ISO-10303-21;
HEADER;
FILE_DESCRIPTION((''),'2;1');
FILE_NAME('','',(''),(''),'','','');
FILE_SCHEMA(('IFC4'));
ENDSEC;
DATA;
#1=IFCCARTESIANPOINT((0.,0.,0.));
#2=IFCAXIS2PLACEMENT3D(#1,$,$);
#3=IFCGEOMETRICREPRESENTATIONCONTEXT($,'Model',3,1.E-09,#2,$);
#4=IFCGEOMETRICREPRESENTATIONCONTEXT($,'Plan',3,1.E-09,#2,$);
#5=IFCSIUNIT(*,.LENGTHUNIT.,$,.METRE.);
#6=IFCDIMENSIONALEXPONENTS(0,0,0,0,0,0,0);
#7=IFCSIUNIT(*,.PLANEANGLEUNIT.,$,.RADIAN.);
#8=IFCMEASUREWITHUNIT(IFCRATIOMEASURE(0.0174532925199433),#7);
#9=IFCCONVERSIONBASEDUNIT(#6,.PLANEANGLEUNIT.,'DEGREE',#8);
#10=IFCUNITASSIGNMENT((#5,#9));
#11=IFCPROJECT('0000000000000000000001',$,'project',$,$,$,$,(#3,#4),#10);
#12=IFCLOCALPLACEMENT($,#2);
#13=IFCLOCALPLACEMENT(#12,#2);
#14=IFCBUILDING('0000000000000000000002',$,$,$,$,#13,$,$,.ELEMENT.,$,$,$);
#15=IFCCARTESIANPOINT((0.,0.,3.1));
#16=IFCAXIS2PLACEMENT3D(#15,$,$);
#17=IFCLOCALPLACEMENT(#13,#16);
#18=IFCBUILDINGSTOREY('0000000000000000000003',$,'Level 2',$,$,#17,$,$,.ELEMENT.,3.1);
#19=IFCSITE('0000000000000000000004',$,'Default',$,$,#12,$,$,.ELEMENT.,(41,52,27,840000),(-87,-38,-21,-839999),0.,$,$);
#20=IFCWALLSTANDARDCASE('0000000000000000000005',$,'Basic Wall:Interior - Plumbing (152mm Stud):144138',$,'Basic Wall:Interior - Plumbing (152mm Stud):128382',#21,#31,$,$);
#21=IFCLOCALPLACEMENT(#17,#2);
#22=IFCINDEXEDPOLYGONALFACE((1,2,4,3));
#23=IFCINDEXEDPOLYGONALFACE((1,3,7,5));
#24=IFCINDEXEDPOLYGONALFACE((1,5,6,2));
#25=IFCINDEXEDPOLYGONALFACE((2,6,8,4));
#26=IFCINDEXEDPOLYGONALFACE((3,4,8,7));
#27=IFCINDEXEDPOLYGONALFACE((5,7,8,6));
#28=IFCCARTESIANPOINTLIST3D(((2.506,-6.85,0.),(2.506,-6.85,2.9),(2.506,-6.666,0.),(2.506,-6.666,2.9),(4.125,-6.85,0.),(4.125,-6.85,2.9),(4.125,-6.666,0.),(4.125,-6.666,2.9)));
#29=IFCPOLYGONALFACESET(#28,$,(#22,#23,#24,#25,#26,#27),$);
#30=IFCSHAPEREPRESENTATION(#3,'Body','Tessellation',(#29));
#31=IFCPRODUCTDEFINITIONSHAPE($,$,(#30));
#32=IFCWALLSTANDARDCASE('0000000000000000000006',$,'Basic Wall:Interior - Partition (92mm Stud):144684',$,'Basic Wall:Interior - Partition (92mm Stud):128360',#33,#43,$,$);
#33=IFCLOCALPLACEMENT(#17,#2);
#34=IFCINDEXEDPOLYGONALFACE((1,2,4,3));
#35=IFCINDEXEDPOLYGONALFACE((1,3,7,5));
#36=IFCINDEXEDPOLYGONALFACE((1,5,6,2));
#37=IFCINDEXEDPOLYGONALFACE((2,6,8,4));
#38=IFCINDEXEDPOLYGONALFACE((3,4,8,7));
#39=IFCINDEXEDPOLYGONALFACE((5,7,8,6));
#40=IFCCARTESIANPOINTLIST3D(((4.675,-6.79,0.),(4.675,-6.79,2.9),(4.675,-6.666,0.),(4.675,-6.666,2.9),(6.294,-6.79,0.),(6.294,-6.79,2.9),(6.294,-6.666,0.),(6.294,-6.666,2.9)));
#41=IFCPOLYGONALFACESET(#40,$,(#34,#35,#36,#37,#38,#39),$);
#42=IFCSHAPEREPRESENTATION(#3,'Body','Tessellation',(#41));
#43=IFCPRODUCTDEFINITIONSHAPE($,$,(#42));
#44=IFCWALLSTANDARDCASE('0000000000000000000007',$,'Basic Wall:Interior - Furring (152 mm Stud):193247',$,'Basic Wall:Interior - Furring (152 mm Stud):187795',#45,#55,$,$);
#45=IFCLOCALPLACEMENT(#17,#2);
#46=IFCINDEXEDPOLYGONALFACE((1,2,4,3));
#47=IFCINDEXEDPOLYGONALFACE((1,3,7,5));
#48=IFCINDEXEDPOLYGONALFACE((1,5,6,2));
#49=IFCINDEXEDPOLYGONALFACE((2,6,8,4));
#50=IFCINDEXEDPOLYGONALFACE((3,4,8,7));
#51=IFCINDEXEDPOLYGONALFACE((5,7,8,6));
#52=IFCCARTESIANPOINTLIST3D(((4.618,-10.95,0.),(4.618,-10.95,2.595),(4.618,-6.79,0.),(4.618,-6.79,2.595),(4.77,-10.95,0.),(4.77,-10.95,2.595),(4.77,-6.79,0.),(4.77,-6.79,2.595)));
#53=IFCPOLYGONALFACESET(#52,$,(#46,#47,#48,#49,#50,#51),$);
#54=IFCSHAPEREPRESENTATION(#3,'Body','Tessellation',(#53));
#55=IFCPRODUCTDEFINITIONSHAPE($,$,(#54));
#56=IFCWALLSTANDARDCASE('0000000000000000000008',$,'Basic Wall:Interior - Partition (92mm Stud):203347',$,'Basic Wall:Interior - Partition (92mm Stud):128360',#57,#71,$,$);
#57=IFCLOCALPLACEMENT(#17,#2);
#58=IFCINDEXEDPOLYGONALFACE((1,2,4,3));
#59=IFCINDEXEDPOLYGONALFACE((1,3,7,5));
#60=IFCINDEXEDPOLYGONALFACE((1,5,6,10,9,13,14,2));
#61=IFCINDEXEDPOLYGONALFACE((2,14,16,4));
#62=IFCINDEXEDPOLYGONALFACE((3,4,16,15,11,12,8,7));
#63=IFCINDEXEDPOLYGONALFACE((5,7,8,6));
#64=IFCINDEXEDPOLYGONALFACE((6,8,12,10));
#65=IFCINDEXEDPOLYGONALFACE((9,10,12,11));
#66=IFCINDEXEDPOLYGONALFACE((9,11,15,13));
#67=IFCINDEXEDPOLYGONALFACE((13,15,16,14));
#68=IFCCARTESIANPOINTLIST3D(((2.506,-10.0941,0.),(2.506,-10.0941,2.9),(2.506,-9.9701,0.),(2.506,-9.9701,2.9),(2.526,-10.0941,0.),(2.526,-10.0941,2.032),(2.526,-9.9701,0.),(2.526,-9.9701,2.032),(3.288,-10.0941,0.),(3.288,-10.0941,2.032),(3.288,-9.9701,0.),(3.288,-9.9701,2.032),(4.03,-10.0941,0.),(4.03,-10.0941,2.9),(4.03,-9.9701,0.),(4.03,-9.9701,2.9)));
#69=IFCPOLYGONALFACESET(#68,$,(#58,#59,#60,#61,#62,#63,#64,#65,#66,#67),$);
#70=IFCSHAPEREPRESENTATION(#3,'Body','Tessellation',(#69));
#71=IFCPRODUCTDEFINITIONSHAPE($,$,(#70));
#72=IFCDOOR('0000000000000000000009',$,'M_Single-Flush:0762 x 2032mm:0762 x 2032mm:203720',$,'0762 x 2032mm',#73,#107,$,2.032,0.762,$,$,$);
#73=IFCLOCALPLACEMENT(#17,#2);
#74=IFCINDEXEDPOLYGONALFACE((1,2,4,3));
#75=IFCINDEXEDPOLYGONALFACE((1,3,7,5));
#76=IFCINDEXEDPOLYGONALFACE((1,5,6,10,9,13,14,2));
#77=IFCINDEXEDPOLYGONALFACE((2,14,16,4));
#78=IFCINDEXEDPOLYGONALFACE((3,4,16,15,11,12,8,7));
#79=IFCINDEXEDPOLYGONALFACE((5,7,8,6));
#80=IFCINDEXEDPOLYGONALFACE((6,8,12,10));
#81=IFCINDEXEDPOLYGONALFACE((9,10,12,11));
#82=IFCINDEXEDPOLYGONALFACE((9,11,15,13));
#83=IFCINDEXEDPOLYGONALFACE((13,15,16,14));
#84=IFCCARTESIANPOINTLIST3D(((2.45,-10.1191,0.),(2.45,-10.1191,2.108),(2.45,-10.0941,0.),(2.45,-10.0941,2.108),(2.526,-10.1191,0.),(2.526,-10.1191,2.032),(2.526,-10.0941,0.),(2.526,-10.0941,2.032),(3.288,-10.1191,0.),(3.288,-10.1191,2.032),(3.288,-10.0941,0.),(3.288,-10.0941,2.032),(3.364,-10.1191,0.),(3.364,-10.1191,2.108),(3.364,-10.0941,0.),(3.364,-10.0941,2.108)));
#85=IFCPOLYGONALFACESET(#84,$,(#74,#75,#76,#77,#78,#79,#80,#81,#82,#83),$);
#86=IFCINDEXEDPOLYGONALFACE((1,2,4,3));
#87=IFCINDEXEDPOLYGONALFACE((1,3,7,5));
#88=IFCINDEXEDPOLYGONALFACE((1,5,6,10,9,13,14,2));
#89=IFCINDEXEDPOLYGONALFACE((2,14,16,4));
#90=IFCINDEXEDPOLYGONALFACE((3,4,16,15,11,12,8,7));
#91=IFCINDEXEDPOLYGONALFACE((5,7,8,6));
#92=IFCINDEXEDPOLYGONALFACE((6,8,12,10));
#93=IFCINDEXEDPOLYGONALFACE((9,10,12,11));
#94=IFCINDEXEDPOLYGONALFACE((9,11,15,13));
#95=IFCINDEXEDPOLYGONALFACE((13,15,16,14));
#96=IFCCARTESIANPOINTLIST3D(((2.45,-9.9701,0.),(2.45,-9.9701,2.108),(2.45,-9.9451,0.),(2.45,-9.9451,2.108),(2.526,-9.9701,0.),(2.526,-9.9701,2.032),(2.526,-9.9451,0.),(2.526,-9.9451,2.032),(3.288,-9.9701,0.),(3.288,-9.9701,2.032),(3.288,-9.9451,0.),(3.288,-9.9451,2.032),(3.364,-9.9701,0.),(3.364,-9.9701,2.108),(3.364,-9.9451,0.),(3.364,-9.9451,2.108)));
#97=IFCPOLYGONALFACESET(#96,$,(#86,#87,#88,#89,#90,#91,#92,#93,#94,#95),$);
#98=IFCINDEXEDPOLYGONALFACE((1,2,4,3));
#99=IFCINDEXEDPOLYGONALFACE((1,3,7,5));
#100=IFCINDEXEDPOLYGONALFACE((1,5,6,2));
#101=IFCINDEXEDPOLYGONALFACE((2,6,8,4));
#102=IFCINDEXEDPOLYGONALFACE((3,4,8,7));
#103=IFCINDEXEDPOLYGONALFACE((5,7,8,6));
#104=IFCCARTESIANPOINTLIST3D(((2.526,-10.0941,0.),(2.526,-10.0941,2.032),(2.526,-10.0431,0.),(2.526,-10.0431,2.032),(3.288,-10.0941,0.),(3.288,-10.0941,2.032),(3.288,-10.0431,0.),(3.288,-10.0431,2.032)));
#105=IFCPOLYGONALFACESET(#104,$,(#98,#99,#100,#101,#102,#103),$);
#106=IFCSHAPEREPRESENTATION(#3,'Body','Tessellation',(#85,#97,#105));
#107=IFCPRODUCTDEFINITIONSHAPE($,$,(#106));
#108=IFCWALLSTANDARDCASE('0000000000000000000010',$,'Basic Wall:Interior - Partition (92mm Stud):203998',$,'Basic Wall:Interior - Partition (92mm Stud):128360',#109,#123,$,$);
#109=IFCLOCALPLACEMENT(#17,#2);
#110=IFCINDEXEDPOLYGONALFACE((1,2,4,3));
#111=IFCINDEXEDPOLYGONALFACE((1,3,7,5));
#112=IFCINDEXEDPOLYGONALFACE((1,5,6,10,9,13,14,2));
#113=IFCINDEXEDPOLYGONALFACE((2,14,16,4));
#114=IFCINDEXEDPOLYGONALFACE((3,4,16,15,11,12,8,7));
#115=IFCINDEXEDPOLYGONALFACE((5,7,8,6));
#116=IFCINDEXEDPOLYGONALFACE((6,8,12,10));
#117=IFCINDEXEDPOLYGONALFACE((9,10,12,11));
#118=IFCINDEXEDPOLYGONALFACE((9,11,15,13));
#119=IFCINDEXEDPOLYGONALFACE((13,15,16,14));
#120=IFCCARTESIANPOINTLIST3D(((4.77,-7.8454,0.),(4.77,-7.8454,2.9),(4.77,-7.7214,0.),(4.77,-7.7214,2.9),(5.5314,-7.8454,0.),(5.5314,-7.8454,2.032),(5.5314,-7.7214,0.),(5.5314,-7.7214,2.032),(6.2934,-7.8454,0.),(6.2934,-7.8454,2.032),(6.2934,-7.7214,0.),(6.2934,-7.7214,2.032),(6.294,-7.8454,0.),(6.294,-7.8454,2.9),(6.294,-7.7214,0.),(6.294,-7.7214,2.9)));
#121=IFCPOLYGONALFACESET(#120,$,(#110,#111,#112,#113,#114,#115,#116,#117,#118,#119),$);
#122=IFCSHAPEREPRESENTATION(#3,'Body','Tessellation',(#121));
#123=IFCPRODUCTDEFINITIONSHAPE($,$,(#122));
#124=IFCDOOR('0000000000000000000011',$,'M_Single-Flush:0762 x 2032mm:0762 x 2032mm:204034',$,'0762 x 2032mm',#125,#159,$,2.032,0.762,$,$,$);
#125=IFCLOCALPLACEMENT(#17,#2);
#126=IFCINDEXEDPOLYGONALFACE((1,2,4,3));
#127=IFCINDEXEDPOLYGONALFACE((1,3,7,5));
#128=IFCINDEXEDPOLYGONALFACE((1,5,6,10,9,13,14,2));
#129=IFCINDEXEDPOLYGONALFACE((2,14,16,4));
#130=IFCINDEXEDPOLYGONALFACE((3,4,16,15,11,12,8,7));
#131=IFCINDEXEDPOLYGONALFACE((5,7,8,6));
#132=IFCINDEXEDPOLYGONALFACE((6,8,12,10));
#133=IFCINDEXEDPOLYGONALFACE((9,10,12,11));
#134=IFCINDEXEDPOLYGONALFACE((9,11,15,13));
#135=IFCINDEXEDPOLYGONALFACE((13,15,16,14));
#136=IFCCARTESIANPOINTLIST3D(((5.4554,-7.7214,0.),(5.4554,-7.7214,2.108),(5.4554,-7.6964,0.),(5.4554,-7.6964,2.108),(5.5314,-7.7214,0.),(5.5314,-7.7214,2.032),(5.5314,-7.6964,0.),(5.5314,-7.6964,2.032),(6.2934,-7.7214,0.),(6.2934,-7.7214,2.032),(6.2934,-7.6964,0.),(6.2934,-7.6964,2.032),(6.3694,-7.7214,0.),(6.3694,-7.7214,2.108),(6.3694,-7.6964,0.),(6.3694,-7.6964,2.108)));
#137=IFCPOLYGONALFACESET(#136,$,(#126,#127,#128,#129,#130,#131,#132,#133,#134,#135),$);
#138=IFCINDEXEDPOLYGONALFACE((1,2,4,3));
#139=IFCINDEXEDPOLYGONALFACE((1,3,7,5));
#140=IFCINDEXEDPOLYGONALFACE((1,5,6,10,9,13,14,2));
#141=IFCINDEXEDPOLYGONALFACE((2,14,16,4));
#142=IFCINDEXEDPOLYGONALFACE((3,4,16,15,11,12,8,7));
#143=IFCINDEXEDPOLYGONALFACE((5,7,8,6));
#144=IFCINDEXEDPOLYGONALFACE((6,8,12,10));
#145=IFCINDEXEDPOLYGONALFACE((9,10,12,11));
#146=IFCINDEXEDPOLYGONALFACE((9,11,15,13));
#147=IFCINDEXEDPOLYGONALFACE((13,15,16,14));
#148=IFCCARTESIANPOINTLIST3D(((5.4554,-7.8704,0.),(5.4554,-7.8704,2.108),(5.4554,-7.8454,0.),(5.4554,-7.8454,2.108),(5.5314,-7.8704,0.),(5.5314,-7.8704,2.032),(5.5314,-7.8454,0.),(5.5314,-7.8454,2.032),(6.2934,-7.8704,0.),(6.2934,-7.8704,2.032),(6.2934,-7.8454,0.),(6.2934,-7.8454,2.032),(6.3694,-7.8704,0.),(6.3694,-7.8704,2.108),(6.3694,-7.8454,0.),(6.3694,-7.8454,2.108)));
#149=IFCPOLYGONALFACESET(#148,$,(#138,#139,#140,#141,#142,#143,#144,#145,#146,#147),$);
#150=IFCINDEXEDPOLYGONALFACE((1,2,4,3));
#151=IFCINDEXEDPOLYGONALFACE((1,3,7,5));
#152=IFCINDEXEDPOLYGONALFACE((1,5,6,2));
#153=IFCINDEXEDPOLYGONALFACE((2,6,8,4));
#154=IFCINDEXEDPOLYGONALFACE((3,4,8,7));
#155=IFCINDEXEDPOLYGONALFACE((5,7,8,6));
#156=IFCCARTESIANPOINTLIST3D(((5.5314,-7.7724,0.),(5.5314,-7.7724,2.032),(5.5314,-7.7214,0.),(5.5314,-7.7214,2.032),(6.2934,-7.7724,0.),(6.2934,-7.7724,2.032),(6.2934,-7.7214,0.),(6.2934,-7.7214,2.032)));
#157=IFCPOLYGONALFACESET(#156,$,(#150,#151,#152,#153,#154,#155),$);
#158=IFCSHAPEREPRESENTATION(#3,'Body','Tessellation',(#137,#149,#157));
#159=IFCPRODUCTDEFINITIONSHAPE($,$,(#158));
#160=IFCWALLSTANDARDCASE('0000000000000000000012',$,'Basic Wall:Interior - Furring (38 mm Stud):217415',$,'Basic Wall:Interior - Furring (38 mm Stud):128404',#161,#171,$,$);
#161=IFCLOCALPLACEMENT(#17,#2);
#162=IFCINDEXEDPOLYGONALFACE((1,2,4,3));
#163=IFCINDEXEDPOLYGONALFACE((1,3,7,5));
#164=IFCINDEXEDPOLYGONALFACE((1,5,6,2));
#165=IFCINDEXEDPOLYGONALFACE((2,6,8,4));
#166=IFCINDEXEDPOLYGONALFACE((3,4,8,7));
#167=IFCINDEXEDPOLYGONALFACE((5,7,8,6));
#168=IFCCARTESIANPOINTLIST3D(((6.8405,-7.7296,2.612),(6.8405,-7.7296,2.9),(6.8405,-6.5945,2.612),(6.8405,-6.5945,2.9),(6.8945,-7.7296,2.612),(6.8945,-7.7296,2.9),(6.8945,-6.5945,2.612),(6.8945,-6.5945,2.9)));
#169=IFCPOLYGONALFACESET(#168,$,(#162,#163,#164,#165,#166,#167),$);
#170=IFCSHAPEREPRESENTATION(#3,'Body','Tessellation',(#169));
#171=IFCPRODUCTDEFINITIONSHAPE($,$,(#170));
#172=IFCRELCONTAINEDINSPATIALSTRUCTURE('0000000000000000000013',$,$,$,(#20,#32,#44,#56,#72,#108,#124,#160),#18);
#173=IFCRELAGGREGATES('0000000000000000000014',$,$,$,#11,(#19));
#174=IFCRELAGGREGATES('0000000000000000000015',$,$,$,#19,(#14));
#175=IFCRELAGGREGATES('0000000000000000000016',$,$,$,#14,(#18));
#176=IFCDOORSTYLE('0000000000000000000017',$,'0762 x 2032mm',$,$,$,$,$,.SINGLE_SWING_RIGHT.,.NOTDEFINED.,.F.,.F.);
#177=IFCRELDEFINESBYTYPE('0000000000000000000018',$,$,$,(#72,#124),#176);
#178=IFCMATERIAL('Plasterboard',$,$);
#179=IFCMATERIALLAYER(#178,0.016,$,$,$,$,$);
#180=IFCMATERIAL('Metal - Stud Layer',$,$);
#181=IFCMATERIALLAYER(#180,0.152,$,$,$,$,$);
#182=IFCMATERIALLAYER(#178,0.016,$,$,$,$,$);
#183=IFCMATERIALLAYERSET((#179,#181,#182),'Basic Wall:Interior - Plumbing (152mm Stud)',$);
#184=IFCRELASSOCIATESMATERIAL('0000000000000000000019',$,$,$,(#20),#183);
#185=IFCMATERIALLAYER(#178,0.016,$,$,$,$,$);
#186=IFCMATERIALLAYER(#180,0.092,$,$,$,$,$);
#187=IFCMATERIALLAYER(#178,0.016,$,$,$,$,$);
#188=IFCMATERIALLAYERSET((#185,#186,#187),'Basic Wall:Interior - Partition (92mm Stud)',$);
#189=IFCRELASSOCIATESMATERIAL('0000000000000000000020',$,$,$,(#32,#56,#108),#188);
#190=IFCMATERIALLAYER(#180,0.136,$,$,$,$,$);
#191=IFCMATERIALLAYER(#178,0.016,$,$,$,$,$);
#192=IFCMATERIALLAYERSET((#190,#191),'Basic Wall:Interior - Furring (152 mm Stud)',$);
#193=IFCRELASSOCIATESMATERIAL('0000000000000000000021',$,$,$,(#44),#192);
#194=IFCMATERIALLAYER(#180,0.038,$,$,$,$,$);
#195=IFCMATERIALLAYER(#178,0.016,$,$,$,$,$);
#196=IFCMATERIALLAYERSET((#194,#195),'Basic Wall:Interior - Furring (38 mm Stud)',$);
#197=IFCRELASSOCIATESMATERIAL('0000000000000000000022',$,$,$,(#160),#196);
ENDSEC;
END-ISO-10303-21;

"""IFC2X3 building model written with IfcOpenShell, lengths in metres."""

from ifc_helpers import new_model, entity, si_unit, converted_unit, frame, frame_2d, origin, origin_2d_with_axis, place, context, project, spatial, polyline, rectangle, outline, extrude, source, transform, mapped, material, layer, layer_set, layer_usage, type_object, type_shapes, element, fill, save


model = new_model("IFC2X3")

# Units and contexts
model_context = context("Model", 3, precision=1e-09, world=origin())
plan_context = context("Plan", 3, precision=1e-09, world=origin())
ifc_project = project(units=[si_unit("LENGTHUNIT", "METRE"), converted_unit("PLANEANGLEUNIT", "DEGREE", entity("IfcRatioMeasure", 0.0174532925199433), si_unit("PLANEANGLEUNIT", "RADIAN"), dimensions=[0, 0, 0, 0, 0, 0, 0])], contexts=[model_context, plan_context])

# Site, building, storey
site_placement = place(None, origin())
site = spatial("IfcSite", under=ifc_project, at=site_placement, Name="Default", CompositionType="ELEMENT", RefLatitude=(41, 52, 27, 840000), RefLongitude=(-87, -38, -21, -839999), RefElevation=0.0)
building_placement = place(site_placement, origin())
building = spatial("IfcBuilding", under=site, at=building_placement, CompositionType="ELEMENT")
storey_placement = place(building_placement, frame((0.0, 0.0, 3.1)))
storey = spatial("IfcBuildingStorey", under=building, at=storey_placement, Name="Level 2", CompositionType="ELEMENT", Elevation=3.1)

# Walls
ifc_material_1 = material(Name="Plasterboard")
ifc_layer_1 = layer(ifc_material_1, 0.016)
ifc_material_2 = material(Name="Metal - Stud Layer")
ifc_layer_2 = layer(ifc_material_2, 0.152)
ifc_layer_3 = layer(ifc_material_1, 0.016)
ifc_layer_set_1 = layer_set([ifc_layer_1, ifc_layer_2, ifc_layer_3], Name="Basic Wall:Interior - Plumbing (152mm Stud)")
ifc_layer_usage_1 = layer_usage(ifc_layer_set_1, "AXIS2", "NEGATIVE", 0.092)
wall_1_placement = place(storey_placement, frame((2.506, -6.758, 0.0)))
element("IfcWallStandardCase", 1, at=wall_1_placement, inside=storey, material=ifc_layer_usage_1, Name="Basic Wall:Interior - Plumbing (152mm Stud):144138", ObjectType="Basic Wall:Interior - Plumbing (152mm Stud):128382", context=model_context, shape_type="SweptSolid", body=[
    extrude(rectangle(XDim=1.619, YDim=0.184, at=frame_2d((0.8095, 0.0), x_axis=(-1.0, 0.0))), origin(), (0.0, 0.0, 1.0), 2.9),
])
ifc_layer_4 = layer(ifc_material_1, 0.016)
ifc_layer_5 = layer(ifc_material_2, 0.092)
ifc_layer_6 = layer(ifc_material_1, 0.016)
ifc_layer_set_2 = layer_set([ifc_layer_4, ifc_layer_5, ifc_layer_6], Name="Basic Wall:Interior - Partition (92mm Stud)")
ifc_layer_usage_2 = layer_usage(ifc_layer_set_2, "AXIS2", "NEGATIVE", 0.062)
wall_2_placement = place(storey_placement, frame((4.675, -6.728, 0.0)))
element("IfcWallStandardCase", 2, at=wall_2_placement, inside=storey, material=ifc_layer_usage_2, Name="Basic Wall:Interior - Partition (92mm Stud):144684", ObjectType="Basic Wall:Interior - Partition (92mm Stud):128360", context=model_context, shape_type="SweptSolid", body=[
    extrude(rectangle(XDim=1.619, YDim=0.124, at=frame_2d((0.8095, 0.0), x_axis=(-1.0, 0.0))), origin(), (0.0, 0.0, 1.0), 2.9),
])
ifc_layer_7 = layer(ifc_material_2, 0.136)
ifc_layer_8 = layer(ifc_material_1, 0.016)
ifc_layer_set_3 = layer_set([ifc_layer_7, ifc_layer_8], Name="Basic Wall:Interior - Furring (152 mm Stud)")
ifc_layer_usage_3 = layer_usage(ifc_layer_set_3, "AXIS2", "POSITIVE", -0.076)
wall_3_placement = place(storey_placement, frame((4.694, -6.79, 0.0), z_axis=(0.0, 0.0, 1.0), x_axis=(0.0, -1.0, 0.0)))
element("IfcWallStandardCase", 3, at=wall_3_placement, inside=storey, material=ifc_layer_usage_3, Name="Basic Wall:Interior - Furring (152 mm Stud):193247", ObjectType="Basic Wall:Interior - Furring (152 mm Stud):187795", context=model_context, shape_type="SweptSolid", body=[
    extrude(rectangle(XDim=4.16, YDim=0.152, at=frame_2d((2.08, 0.0), x_axis=(-1.0, 0.0))), origin(), (0.0, 0.0, 1.0), 2.595),
])

# Walls, openings, doors
ifc_layer_usage_4 = layer_usage(ifc_layer_set_2, "AXIS2", "NEGATIVE", 0.062)
wall_4_placement = place(storey_placement, frame((4.03, -10.0321, 0.0), z_axis=(0.0, 0.0, 1.0), x_axis=(-1.0, 0.0, 0.0)))
wall_4 = element("IfcWallStandardCase", 4, at=wall_4_placement, inside=storey, material=ifc_layer_usage_4, Name="Basic Wall:Interior - Partition (92mm Stud):203347", ObjectType="Basic Wall:Interior - Partition (92mm Stud):128360", context=model_context, shape_type="SweptSolid", body=[
    extrude(rectangle(XDim=1.524, YDim=0.124, at=frame_2d((0.762, 0.0), x_axis=(-1.0, 0.0))), origin(), (0.0, 0.0, 1.0), 2.9),
])
opening_1_placement = place(wall_4_placement, frame((0.742, -0.062, 0.0)))
opening_1 = element("IfcOpeningElement", 5, at=opening_1_placement, cuts=wall_4, ObjectType="Opening", context=model_context, shape_type="SweptSolid", body=[
    extrude(rectangle(XDim=0.762, YDim=2.032, at=frame_2d((1.016, 0.381), x_axis=(0.0, 1.0))), frame((0.0, 0.0, 0.0), z_axis=(0.0, 1.0, 0.0), x_axis=(0.0, 0.0, 1.0)), (0.0, 0.0, 1.0), 0.124),
])
door_style = type_object("IfcDoorStyle", Name="0762 x 2032mm", ConstructionType="NOTDEFINED", OperationType="SINGLE_SWING_RIGHT", ParameterTakesPrecedence=False, Sizeable=False)
shared_shape = source(origin(), model_context, "Body", "SweptSolid", [
    extrude(outline(polyline([(-0.457, -1.073), (0.457, -1.073), (0.457, 1.035), (0.381, 1.035), (0.381, -0.997), (-0.381, -0.997), (-0.381, 1.035), (-0.457, 1.035), (-0.457, -1.073)])), frame((0.381, 0.124, 1.035), z_axis=(0.0, 1.0, 0.0), x_axis=(1.0, 0.0, 0.0)), (0.0, 0.0, 1.0), 0.025),
    extrude(outline(polyline([(-1.073, -0.457), (1.035, -0.457), (1.035, -0.381), (-0.997, -0.381), (-0.997, 0.381), (1.035, 0.381), (1.035, 0.457), (-1.073, 0.457), (-1.073, -0.457)])), frame((0.381, -0.025, 1.035), z_axis=(0.0, 1.0, 0.0), x_axis=(0.0, 0.0, -1.0)), (0.0, 0.0, 1.0), 0.025),
    extrude(rectangle(XDim=0.051, YDim=0.762, at=origin_2d_with_axis()), frame((0.381, 0.0985, 0.0), z_axis=(0.0, 0.0, 1.0), x_axis=(0.0, 1.0, 0.0)), (0.0, 0.0, 1.0), 2.032),
])
type_shapes(door_style, [shared_shape])
door_1_placement = place(opening_1_placement, origin())
door_1 = element("IfcDoor", 6, at=door_1_placement, inside=storey, type_object=door_style, Name="M_Single-Flush:0762 x 2032mm:0762 x 2032mm:203720", ObjectType="0762 x 2032mm", OverallHeight=2.032, OverallWidth=0.762, context=model_context, shape_type="MappedRepresentation", body=[
    mapped(shared_shape, transform((0.0, 0.0, 0.0), scale=1.0)),
])
fill(opening_1, door_1)
ifc_layer_usage_5 = layer_usage(ifc_layer_set_2, "AXIS2", "POSITIVE", -0.062)
wall_5_placement = place(storey_placement, frame((4.77, -7.7834, 0.0)))
wall_5 = element("IfcWallStandardCase", 7, at=wall_5_placement, inside=storey, material=ifc_layer_usage_5, Name="Basic Wall:Interior - Partition (92mm Stud):203998", ObjectType="Basic Wall:Interior - Partition (92mm Stud):128360", context=model_context, shape_type="SweptSolid", body=[
    extrude(rectangle(XDim=1.524, YDim=0.124, at=frame_2d((0.762, 0.0), x_axis=(-1.0, 0.0))), origin(), (0.0, 0.0, 1.0), 2.9),
])
opening_2_placement = place(wall_5_placement, frame((0.7614, -0.062, 0.0)))
opening_2 = element("IfcOpeningElement", 8, at=opening_2_placement, cuts=wall_5, ObjectType="Opening", context=model_context, shape_type="SweptSolid", body=[
    extrude(rectangle(XDim=0.762, YDim=2.032, at=frame_2d((1.016, 0.381), x_axis=(0.0, 1.0))), frame((0.0, 0.0, 0.0), z_axis=(0.0, 1.0, 0.0), x_axis=(0.0, 0.0, 1.0)), (0.0, 0.0, 1.0), 0.124),
])
door_2_placement = place(opening_2_placement, origin())
door_2 = element("IfcDoor", 9, at=door_2_placement, inside=storey, type_object=door_style, Name="M_Single-Flush:0762 x 2032mm:0762 x 2032mm:204034", ObjectType="0762 x 2032mm", OverallHeight=2.032, OverallWidth=0.762, context=model_context, shape_type="MappedRepresentation", body=[
    mapped(shared_shape, transform((0.0, 0.0, 0.0), scale=1.0)),
])
fill(opening_2, door_2)

# Wall
ifc_layer_9 = layer(ifc_material_2, 0.038)
ifc_layer_10 = layer(ifc_material_1, 0.016)
ifc_layer_set_4 = layer_set([ifc_layer_9, ifc_layer_10], Name="Basic Wall:Interior - Furring (38 mm Stud)")
ifc_layer_usage_6 = layer_usage(ifc_layer_set_4, "AXIS2", "NEGATIVE", 0.027)
wall_6_placement = place(storey_placement, frame((6.8675, -7.7296, 2.612), z_axis=(0.0, 0.0, 1.0), x_axis=(0.0, 1.0, 0.0)))
element("IfcWallStandardCase", 10, at=wall_6_placement, inside=storey, material=ifc_layer_usage_6, Name="Basic Wall:Interior - Furring (38 mm Stud):217415", ObjectType="Basic Wall:Interior - Furring (38 mm Stud):128404", context=model_context, shape_type="SweptSolid", body=[
    extrude(rectangle(XDim=1.1351, YDim=0.054, at=frame_2d((0.5675, 0.0), x_axis=(-1.0, 0.0))), origin(), (0.0, 0.0, 1.0), 0.288),
])

save(model, "model.ifc")
